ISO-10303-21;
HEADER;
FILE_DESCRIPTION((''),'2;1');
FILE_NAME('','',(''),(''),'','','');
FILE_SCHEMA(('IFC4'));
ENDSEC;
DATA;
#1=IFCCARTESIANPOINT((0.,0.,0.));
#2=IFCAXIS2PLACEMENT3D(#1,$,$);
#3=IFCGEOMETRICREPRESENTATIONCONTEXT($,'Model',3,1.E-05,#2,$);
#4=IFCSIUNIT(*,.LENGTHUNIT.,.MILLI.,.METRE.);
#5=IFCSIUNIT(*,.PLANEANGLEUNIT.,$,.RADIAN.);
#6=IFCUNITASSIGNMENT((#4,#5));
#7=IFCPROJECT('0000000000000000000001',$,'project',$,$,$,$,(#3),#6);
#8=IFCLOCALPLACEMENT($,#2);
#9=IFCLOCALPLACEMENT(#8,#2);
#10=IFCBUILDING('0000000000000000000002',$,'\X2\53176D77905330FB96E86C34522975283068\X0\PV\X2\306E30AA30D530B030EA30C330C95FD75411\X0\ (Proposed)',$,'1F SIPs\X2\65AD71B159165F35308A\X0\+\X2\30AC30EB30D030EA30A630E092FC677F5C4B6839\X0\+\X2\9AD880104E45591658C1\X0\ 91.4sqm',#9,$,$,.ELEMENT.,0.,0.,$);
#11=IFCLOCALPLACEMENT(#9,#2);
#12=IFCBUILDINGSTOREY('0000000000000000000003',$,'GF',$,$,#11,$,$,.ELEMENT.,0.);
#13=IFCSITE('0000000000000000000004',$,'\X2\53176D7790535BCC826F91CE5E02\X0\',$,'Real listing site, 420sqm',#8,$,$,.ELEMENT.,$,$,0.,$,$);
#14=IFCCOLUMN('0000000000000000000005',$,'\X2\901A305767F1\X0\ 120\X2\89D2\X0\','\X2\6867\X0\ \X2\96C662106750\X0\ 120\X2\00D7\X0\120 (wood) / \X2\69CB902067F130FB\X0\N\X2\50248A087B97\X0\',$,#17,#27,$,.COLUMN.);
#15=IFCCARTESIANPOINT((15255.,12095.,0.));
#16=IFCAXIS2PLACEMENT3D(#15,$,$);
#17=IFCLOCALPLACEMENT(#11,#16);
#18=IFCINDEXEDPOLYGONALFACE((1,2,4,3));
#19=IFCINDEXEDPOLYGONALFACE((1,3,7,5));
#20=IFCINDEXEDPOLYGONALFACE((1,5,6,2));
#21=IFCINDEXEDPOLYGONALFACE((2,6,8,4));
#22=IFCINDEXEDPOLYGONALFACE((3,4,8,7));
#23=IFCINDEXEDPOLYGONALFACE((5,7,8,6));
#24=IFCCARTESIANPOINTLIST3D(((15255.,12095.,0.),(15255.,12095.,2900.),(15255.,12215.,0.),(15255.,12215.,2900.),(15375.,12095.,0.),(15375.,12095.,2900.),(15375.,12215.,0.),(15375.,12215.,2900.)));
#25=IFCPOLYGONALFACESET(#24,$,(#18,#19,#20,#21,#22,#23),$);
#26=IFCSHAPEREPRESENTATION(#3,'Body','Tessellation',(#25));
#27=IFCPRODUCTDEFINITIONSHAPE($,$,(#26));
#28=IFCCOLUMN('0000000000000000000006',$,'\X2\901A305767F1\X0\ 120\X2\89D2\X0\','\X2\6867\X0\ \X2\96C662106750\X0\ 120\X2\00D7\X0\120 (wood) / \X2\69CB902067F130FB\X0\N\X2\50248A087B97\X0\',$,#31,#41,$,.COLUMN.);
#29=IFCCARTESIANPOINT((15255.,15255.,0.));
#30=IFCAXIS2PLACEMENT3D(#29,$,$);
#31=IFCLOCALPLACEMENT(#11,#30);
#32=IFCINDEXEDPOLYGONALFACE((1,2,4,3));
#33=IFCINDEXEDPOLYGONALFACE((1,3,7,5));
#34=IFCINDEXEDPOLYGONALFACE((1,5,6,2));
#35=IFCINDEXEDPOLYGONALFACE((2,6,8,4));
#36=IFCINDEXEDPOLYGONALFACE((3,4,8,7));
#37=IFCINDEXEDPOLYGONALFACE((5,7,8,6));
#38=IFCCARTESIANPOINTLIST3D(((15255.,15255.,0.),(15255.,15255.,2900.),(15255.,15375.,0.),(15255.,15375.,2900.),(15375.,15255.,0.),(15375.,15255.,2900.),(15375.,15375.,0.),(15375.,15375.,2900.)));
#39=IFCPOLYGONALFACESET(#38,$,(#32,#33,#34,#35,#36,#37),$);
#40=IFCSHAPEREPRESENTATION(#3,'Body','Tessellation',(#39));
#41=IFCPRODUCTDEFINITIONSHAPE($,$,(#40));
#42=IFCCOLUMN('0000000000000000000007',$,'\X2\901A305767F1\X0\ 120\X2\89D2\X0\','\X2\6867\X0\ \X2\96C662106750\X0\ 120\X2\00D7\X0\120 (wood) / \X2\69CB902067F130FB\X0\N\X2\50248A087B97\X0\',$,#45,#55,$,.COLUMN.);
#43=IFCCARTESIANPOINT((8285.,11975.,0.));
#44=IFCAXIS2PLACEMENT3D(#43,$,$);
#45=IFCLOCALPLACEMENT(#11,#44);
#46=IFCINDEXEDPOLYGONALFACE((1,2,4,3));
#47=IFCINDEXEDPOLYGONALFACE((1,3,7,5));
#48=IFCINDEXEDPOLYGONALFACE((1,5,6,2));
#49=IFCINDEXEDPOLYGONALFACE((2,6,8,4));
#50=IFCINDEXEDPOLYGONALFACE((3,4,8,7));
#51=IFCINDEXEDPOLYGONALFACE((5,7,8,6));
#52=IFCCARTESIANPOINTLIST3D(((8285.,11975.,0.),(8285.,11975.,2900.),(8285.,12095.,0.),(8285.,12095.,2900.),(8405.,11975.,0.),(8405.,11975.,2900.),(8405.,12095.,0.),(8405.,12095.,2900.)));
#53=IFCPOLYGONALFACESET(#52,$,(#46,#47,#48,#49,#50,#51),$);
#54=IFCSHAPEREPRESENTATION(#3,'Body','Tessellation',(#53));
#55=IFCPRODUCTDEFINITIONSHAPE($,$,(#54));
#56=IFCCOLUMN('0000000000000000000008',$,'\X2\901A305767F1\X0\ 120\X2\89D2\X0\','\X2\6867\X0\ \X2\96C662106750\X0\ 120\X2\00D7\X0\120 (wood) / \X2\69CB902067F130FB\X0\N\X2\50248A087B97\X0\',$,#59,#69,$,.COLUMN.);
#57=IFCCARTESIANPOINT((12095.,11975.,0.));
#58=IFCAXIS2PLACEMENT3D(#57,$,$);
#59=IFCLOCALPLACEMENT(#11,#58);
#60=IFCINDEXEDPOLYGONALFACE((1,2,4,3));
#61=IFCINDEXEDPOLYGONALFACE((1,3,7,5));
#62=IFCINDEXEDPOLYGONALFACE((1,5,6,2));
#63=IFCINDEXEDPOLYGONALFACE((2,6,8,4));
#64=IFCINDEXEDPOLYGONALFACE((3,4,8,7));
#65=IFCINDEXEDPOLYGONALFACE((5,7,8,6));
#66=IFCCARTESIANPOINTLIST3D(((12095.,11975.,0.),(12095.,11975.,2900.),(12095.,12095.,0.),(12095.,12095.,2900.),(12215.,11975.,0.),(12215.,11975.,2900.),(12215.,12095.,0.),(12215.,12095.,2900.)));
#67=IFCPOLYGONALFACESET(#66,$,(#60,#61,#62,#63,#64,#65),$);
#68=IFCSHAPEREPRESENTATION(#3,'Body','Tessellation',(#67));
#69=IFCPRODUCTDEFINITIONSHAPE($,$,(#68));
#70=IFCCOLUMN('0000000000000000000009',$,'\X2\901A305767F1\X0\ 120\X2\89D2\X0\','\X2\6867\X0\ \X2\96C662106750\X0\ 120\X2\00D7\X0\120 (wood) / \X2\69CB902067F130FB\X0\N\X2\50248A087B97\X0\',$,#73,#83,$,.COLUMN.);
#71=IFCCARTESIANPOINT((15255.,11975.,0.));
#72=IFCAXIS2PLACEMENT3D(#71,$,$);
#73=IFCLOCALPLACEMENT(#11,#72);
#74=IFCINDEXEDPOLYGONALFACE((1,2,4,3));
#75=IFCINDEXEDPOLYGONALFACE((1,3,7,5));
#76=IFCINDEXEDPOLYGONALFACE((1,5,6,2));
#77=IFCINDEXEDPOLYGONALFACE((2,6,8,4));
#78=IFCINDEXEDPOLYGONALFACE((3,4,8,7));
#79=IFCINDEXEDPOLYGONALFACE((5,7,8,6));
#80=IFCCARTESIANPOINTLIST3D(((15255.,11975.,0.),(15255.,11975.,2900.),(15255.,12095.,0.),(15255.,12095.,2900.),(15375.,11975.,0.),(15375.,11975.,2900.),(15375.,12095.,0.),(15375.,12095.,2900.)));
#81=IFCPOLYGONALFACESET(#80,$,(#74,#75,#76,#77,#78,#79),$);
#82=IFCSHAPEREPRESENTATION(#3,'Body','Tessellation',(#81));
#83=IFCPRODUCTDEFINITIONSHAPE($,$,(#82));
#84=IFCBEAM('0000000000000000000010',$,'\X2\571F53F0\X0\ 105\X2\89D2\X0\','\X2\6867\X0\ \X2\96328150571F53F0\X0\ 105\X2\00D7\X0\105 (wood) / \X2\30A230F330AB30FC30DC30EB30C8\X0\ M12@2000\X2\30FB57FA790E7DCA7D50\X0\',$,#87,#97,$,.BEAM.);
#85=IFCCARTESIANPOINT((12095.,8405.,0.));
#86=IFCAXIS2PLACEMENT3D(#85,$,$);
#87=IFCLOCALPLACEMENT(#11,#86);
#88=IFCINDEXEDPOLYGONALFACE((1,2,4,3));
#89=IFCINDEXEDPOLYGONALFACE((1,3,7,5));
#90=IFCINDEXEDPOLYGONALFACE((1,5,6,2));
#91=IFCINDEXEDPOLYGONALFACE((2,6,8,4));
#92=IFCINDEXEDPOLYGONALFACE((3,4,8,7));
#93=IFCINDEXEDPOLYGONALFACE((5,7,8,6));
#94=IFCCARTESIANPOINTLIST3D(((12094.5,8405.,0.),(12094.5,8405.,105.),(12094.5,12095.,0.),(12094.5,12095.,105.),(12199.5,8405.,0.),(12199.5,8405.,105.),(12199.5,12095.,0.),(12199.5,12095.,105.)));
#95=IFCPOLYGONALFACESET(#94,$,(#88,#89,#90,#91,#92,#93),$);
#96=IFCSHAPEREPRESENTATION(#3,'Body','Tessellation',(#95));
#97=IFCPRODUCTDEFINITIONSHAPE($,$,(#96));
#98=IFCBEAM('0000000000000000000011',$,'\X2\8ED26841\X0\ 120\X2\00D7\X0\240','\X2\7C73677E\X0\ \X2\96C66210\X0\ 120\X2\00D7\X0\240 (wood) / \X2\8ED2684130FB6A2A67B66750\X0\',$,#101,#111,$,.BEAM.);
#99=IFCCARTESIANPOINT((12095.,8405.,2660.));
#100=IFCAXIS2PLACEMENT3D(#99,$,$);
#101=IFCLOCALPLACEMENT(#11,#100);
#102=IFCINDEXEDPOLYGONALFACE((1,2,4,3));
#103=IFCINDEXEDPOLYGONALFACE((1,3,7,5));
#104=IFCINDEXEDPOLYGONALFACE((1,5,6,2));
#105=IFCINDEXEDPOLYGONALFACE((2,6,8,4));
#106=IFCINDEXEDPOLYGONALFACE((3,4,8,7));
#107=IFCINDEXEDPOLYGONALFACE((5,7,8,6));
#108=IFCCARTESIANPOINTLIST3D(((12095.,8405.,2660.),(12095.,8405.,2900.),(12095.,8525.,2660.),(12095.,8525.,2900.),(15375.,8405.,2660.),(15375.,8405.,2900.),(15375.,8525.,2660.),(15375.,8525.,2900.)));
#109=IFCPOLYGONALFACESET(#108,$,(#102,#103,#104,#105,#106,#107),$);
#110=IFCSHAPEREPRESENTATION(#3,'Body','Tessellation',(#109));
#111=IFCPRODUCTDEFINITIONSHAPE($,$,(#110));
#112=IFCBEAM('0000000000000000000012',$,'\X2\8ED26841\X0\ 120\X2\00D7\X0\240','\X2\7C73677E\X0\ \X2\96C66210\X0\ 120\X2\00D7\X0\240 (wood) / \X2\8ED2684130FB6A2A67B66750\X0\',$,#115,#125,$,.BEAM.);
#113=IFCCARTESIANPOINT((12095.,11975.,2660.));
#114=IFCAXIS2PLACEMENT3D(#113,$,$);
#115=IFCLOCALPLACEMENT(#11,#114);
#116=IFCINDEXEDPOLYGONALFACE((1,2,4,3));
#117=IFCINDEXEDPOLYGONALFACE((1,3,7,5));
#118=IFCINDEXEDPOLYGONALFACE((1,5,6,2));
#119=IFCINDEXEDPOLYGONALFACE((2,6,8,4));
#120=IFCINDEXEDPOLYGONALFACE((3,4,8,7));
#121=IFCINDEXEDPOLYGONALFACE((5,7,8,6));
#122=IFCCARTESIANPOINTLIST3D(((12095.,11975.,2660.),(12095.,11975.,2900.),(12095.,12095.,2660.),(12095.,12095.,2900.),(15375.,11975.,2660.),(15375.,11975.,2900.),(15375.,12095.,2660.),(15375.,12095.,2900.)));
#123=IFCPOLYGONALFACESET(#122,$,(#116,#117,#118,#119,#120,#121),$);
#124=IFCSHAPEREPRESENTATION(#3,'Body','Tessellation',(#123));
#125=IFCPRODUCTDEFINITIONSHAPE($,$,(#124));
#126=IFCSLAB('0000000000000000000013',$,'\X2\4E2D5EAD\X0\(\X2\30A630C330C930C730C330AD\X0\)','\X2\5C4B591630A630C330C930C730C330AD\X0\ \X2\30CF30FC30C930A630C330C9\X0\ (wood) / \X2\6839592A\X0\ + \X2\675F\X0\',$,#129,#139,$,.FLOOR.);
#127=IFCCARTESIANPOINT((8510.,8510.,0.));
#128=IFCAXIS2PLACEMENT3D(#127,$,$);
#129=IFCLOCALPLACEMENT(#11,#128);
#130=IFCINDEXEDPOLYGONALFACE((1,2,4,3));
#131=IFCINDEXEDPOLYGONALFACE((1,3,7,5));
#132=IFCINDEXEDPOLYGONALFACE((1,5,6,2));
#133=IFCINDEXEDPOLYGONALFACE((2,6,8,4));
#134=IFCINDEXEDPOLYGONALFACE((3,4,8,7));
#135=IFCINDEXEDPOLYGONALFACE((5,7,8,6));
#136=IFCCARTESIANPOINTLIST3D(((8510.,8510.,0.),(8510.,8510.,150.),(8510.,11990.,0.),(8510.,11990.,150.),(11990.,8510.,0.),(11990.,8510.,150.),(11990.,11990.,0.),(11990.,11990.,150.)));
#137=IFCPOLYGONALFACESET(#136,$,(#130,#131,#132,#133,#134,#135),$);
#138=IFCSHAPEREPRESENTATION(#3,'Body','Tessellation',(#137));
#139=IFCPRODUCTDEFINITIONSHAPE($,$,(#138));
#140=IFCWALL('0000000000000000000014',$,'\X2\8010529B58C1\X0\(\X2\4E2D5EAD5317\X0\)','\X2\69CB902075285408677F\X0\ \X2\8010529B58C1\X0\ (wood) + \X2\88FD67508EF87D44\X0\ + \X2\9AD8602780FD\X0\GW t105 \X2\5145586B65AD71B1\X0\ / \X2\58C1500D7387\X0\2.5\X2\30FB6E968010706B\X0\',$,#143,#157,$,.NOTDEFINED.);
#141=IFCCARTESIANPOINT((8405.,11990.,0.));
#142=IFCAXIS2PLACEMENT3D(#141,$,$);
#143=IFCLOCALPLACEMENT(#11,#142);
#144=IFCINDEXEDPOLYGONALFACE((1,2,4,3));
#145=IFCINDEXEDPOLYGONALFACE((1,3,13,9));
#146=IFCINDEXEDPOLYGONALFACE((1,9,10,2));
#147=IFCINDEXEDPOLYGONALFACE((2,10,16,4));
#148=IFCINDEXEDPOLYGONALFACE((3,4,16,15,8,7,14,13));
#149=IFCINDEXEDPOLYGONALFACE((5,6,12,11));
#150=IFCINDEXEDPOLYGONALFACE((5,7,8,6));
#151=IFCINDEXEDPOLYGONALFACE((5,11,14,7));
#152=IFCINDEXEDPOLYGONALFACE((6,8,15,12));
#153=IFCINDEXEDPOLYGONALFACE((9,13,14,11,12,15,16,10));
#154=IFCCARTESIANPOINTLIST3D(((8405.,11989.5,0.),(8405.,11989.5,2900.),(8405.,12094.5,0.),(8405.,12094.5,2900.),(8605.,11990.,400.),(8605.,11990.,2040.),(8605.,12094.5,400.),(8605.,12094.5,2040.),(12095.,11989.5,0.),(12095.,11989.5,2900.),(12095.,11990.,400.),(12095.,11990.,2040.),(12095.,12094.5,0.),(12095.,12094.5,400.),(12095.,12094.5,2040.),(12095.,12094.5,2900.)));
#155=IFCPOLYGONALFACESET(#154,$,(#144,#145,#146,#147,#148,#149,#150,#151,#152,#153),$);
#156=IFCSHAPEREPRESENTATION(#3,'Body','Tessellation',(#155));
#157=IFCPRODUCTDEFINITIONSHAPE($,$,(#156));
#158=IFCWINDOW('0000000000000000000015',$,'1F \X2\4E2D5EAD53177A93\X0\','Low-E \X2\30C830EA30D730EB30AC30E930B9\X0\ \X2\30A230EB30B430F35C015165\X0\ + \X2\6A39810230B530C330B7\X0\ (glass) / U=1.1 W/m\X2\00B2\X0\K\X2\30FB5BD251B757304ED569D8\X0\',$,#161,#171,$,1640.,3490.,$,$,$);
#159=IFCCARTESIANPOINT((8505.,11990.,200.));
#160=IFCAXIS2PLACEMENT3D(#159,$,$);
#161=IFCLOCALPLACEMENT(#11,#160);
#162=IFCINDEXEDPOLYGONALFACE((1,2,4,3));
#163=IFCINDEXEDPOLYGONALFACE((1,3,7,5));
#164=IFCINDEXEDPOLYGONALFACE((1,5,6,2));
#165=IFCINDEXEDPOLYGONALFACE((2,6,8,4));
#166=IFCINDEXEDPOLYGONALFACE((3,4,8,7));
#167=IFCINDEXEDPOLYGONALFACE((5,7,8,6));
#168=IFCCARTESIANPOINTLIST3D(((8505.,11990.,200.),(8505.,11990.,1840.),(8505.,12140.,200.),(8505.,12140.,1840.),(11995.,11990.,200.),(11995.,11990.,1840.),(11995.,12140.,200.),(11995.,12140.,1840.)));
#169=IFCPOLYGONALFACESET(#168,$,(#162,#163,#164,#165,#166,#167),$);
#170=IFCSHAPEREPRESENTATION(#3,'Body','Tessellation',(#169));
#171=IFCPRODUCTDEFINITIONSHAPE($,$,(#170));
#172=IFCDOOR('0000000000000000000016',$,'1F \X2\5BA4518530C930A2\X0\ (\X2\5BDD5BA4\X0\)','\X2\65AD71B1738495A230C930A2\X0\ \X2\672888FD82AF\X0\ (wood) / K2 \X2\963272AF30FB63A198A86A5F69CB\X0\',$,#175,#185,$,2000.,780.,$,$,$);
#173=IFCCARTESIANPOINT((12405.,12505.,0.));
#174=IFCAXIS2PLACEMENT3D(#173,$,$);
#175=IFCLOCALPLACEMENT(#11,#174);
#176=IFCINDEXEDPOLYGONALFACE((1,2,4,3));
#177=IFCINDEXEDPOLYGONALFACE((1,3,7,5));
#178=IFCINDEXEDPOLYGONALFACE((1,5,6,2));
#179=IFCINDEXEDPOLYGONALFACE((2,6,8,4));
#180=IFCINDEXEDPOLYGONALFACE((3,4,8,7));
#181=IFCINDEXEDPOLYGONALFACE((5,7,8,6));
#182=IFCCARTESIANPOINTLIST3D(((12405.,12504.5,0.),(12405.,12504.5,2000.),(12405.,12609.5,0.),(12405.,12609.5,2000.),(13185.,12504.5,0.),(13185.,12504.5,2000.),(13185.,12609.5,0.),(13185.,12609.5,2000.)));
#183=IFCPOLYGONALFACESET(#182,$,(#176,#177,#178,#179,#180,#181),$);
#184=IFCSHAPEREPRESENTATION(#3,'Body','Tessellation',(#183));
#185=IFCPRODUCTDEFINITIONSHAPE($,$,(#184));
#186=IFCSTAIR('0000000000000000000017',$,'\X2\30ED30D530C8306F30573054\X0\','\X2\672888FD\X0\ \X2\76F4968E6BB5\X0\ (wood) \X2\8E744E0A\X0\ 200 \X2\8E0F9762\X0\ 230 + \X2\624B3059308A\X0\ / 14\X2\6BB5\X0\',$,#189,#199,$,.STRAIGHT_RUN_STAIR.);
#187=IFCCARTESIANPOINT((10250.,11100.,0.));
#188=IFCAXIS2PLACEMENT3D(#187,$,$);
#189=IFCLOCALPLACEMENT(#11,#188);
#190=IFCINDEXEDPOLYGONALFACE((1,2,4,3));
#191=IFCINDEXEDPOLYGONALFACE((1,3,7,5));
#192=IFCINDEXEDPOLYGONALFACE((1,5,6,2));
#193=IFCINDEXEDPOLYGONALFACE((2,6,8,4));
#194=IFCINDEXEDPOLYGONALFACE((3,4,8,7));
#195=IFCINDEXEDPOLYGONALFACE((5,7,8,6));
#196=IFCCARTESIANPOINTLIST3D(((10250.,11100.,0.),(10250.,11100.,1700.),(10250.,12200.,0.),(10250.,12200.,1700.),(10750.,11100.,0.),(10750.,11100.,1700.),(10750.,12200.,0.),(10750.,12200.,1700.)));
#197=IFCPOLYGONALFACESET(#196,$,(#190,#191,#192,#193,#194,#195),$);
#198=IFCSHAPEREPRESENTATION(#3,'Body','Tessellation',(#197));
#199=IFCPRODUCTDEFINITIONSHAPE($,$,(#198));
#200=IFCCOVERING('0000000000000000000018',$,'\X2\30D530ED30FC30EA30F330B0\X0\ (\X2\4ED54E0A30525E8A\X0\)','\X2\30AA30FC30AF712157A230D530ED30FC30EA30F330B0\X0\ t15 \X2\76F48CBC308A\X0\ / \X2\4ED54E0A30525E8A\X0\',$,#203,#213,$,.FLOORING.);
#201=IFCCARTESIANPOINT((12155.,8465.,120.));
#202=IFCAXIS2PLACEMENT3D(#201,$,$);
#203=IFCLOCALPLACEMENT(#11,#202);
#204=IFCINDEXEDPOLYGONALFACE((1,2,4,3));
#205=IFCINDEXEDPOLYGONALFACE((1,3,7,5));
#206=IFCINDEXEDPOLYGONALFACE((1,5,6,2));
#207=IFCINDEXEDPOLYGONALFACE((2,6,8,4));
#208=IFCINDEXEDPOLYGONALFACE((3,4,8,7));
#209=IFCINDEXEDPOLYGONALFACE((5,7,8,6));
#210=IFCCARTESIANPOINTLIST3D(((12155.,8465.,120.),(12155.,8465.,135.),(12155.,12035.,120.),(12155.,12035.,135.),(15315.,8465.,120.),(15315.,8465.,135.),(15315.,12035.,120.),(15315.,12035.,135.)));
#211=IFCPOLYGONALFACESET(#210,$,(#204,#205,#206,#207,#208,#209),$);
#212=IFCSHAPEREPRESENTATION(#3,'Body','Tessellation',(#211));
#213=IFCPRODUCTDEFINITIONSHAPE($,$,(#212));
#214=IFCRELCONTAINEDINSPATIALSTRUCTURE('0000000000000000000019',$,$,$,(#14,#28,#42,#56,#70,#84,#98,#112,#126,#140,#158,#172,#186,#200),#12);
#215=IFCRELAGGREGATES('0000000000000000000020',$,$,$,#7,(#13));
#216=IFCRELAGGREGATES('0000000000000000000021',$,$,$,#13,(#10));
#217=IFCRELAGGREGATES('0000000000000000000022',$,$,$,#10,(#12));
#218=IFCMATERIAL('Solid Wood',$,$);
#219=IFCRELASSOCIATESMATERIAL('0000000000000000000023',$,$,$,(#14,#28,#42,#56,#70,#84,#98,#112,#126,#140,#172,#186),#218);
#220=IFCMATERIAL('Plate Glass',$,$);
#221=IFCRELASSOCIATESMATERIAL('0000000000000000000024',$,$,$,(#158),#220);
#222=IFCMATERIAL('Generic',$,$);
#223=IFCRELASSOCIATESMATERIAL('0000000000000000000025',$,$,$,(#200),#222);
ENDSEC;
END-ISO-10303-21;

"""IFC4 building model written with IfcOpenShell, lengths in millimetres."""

from ifc_helpers import new_model, si_unit, frame, frame_2d, origin, place, context, project, spatial, rectangle, extrude, material, element, fill, save


model = new_model("IFC4")

# Units and contexts
model_context = context("Model", 3, precision=1e-05, world=origin())
ifc_project = project(units=[si_unit("LENGTHUNIT", "METRE", prefix="MILLI"), si_unit("PLANEANGLEUNIT", "RADIAN")], contexts=[model_context])

# Site, building, storey
site_placement = place(None, origin())
site = spatial("IfcSite", under=ifc_project, at=site_placement, Name="北海道富良野市", ObjectType="Real listing site, 420sqm", CompositionType="ELEMENT", RefElevation=0.0)
building_placement = place(site_placement, origin())
building = spatial("IfcBuilding", under=site, at=building_placement, Name="北海道・雨水利用とPVのオフグリッド志向 (Proposed)", ObjectType="1F SIPs断熱外張り+ガルバリウム鋼板屋根+高耐久外壁 91.4sqm", CompositionType="ELEMENT", ElevationOfRefHeight=0.0, ElevationOfTerrain=0.0)
storey_placement = place(building_placement, origin())
storey = spatial("IfcBuildingStorey", under=building, at=storey_placement, Name="GF", CompositionType="ELEMENT", Elevation=0.0)

# Columns
ifc_material_1 = material(Name="Solid Wood")
column_1_placement = place(storey_placement, frame((15255.0, 12095.0, 0.0)))
element("IfcColumn", 1, at=column_1_placement, inside=storey, material=ifc_material_1, Name="通し柱 120角", Description="桧 集成材 120×120 (wood) / 構造柱・N値計算", PredefinedType="COLUMN", context=model_context, shape_type="SweptSolid", body=[
    extrude(rectangle(XDim=120.0, YDim=120.0, at=frame_2d((60.0, 60.0))), frame((15255.0, 12095.0, 0.0)), (0.0, 0.0, 1.0), 2900.0),
])
column_2_placement = place(storey_placement, frame((15255.0, 15255.0, 0.0)))
element("IfcColumn", 2, at=column_2_placement, inside=storey, material=ifc_material_1, Name="通し柱 120角", Description="桧 集成材 120×120 (wood) / 構造柱・N値計算", PredefinedType="COLUMN", context=model_context, shape_type="SweptSolid", body=[
    extrude(rectangle(XDim=120.0, YDim=120.0, at=frame_2d((60.0, 60.0))), frame((15255.0, 15255.0, 0.0)), (0.0, 0.0, 1.0), 2900.0),
])
column_3_placement = place(storey_placement, frame((8285.0, 11975.0, 0.0)))
element("IfcColumn", 3, at=column_3_placement, inside=storey, material=ifc_material_1, Name="通し柱 120角", Description="桧 集成材 120×120 (wood) / 構造柱・N値計算", PredefinedType="COLUMN", context=model_context, shape_type="SweptSolid", body=[
    extrude(rectangle(XDim=120.0, YDim=120.0, at=frame_2d((60.0, 60.0))), frame((8285.0, 11975.0, 0.0)), (0.0, 0.0, 1.0), 2900.0),
])
column_4_placement = place(storey_placement, frame((12095.0, 11975.0, 0.0)))
element("IfcColumn", 4, at=column_4_placement, inside=storey, material=ifc_material_1, Name="通し柱 120角", Description="桧 集成材 120×120 (wood) / 構造柱・N値計算", PredefinedType="COLUMN", context=model_context, shape_type="SweptSolid", body=[
    extrude(rectangle(XDim=120.0, YDim=120.0, at=frame_2d((60.0, 60.0))), frame((12095.0, 11975.0, 0.0)), (0.0, 0.0, 1.0), 2900.0),
])
column_5_placement = place(storey_placement, frame((15255.0, 11975.0, 0.0)))
element("IfcColumn", 5, at=column_5_placement, inside=storey, material=ifc_material_1, Name="通し柱 120角", Description="桧 集成材 120×120 (wood) / 構造柱・N値計算", PredefinedType="COLUMN", context=model_context, shape_type="SweptSolid", body=[
    extrude(rectangle(XDim=120.0, YDim=120.0, at=frame_2d((60.0, 60.0))), frame((15255.0, 11975.0, 0.0)), (0.0, 0.0, 1.0), 2900.0),
])

# Beams
beam_1_placement = place(storey_placement, frame((12095.0, 8405.0, 0.0)))
element("IfcBeam", 6, at=beam_1_placement, inside=storey, material=ifc_material_1, Name="土台 105角", Description="桧 防腐土台 105×105 (wood) / アンカーボルト M12@2000・基礎緊結", PredefinedType="BEAM", context=model_context, shape_type="SweptSolid", body=[
    extrude(rectangle(XDim=105.0, YDim=3690.0, at=frame_2d((52.0, 1845.0))), frame((12095.0, 8405.0, 0.0)), (0.0, 0.0, 1.0), 105.0),
])
beam_2_placement = place(storey_placement, frame((12095.0, 8405.0, 2660.0)))
element("IfcBeam", 7, at=beam_2_placement, inside=storey, material=ifc_material_1, Name="軒桁 120×240", Description="米松 集成 120×240 (wood) / 軒桁・横架材", PredefinedType="BEAM", context=model_context, shape_type="SweptSolid", body=[
    extrude(rectangle(XDim=3280.0, YDim=120.0, at=frame_2d((1640.0, 60.0))), frame((12095.0, 8405.0, 2660.0)), (0.0, 0.0, 1.0), 240.0),
])
beam_3_placement = place(storey_placement, frame((12095.0, 11975.0, 2660.0)))
element("IfcBeam", 8, at=beam_3_placement, inside=storey, material=ifc_material_1, Name="軒桁 120×240", Description="米松 集成 120×240 (wood) / 軒桁・横架材", PredefinedType="BEAM", context=model_context, shape_type="SweptSolid", body=[
    extrude(rectangle(XDim=3280.0, YDim=120.0, at=frame_2d((1640.0, 60.0))), frame((12095.0, 11975.0, 2660.0)), (0.0, 0.0, 1.0), 240.0),
])

# Slab
slab_placement = place(storey_placement, frame((8510.0, 8510.0, 0.0)))
element("IfcSlab", 9, at=slab_placement, inside=storey, material=ifc_material_1, Name="中庭(ウッドデッキ)", Description="屋外ウッドデッキ ハードウッド (wood) / 根太 + 束", PredefinedType="FLOOR", context=model_context, shape_type="SweptSolid", body=[
    extrude(rectangle(XDim=3480.0, YDim=3480.0, at=frame_2d((1740.0, 1740.0))), frame((8510.0, 8510.0, 0.0)), (0.0, 0.0, 1.0), 150.0),
])

# Wall, opening, window
wall_1_placement = place(storey_placement, frame((8405.0, 11990.0, 0.0)))
wall_1 = element("IfcWall", 10, at=wall_1_placement, inside=storey, material=ifc_material_1, Name="耐力壁(中庭北)", Description="構造用合板 耐力壁 (wood) + 製材軸組 + 高性能GW t105 充填断熱 / 壁倍率2.5・準耐火", PredefinedType="NOTDEFINED", context=model_context, shape_type="SweptSolid", body=[
    extrude(rectangle(XDim=3690.0, YDim=105.0, at=frame_2d((1845.0, 52.0))), frame((8405.0, 11990.0, 0.0)), (0.0, 0.0, 1.0), 2900.0),
])
opening_placement = place(storey_placement, frame((8505.0, 11990.0, 200.0)))
opening = element("IfcOpeningElement", 11, at=opening_placement, cuts=wall_1, PredefinedType="NOTDEFINED", context=model_context, shape_type="SweptSolid", body=[
    extrude(rectangle(XDim=3490.0, YDim=150.0, at=frame_2d((1745.0, 75.0))), frame((8505.0, 11990.0, 200.0)), (0.0, 0.0, 1.0), 1640.0),
])
ifc_material_2 = material(Name="Plate Glass")
window_placement = place(storey_placement, frame((8505.0, 11990.0, 200.0)))
window = element("IfcWindow", 12, at=window_placement, inside=storey, material=ifc_material_2, Name="1F 中庭北窓", Description="Low-E トリプルガラス アルゴン封入 + 樹脂サッシ (glass) / U=1.1 W/m²K・寒冷地仕様", OverallHeight=1640.0, OverallWidth=3490.0, context=model_context, shape_type="SweptSolid", body=[
    extrude(rectangle(XDim=3490.0, YDim=150.0, at=frame_2d((1745.0, 75.0))), frame((8505.0, 11990.0, 200.0)), (0.0, 0.0, 1.0), 1640.0),
])
fill(opening, window)

# Door
door_placement = place(storey_placement, frame((12405.0, 12505.0, 0.0)))
element("IfcDoor", 13, at=door_placement, inside=storey, material=ifc_material_1, Name="1F 室内ドア (寝室)", Description="断熱玄関ドア 木製芯 (wood) / K2 防犯・採風機構", OverallHeight=2000.0, OverallWidth=780.0, context=model_context, shape_type="SweptSolid", body=[
    extrude(rectangle(XDim=780.0, YDim=105.0, at=frame_2d((390.0, 52.0))), frame((12405.0, 12505.0, 0.0)), (0.0, 0.0, 1.0), 2000.0),
])

# Stair
stair_placement = place(storey_placement, frame((10250.0, 11100.0, 0.0)))
element("IfcStair", 14, at=stair_placement, inside=storey, material=ifc_material_1, Name="ロフトはしご", Description="木製 直階段 (wood) 蹴上 200 踏面 230 + 手すり / 14段", PredefinedType="STRAIGHT_RUN_STAIR", context=model_context, shape_type="SweptSolid", body=[
    extrude(rectangle(XDim=500.0, YDim=1100.0, at=frame_2d((250.0, 550.0))), frame((10250.0, 11100.0, 0.0)), (0.0, 0.0, 1.0), 1700.0),
])

# Covering
ifc_material_3 = material(Name="Generic")
covering_placement = place(storey_placement, frame((12155.0, 8465.0, 120.0)))
element("IfcCovering", 15, at=covering_placement, inside=storey, material=ifc_material_3, Name="フローリング (仕上げ床)", Description="オーク無垢フローリング t15 直貼り / 仕上げ床", PredefinedType="FLOORING", context=model_context, shape_type="SweptSolid", body=[
    extrude(rectangle(XDim=3160.0, YDim=3570.0, at=frame_2d((1580.0, 1785.0))), frame((12155.0, 8465.0, 120.0)), (0.0, 0.0, 1.0), 15.0),
])

save(model, "model.ifc")
